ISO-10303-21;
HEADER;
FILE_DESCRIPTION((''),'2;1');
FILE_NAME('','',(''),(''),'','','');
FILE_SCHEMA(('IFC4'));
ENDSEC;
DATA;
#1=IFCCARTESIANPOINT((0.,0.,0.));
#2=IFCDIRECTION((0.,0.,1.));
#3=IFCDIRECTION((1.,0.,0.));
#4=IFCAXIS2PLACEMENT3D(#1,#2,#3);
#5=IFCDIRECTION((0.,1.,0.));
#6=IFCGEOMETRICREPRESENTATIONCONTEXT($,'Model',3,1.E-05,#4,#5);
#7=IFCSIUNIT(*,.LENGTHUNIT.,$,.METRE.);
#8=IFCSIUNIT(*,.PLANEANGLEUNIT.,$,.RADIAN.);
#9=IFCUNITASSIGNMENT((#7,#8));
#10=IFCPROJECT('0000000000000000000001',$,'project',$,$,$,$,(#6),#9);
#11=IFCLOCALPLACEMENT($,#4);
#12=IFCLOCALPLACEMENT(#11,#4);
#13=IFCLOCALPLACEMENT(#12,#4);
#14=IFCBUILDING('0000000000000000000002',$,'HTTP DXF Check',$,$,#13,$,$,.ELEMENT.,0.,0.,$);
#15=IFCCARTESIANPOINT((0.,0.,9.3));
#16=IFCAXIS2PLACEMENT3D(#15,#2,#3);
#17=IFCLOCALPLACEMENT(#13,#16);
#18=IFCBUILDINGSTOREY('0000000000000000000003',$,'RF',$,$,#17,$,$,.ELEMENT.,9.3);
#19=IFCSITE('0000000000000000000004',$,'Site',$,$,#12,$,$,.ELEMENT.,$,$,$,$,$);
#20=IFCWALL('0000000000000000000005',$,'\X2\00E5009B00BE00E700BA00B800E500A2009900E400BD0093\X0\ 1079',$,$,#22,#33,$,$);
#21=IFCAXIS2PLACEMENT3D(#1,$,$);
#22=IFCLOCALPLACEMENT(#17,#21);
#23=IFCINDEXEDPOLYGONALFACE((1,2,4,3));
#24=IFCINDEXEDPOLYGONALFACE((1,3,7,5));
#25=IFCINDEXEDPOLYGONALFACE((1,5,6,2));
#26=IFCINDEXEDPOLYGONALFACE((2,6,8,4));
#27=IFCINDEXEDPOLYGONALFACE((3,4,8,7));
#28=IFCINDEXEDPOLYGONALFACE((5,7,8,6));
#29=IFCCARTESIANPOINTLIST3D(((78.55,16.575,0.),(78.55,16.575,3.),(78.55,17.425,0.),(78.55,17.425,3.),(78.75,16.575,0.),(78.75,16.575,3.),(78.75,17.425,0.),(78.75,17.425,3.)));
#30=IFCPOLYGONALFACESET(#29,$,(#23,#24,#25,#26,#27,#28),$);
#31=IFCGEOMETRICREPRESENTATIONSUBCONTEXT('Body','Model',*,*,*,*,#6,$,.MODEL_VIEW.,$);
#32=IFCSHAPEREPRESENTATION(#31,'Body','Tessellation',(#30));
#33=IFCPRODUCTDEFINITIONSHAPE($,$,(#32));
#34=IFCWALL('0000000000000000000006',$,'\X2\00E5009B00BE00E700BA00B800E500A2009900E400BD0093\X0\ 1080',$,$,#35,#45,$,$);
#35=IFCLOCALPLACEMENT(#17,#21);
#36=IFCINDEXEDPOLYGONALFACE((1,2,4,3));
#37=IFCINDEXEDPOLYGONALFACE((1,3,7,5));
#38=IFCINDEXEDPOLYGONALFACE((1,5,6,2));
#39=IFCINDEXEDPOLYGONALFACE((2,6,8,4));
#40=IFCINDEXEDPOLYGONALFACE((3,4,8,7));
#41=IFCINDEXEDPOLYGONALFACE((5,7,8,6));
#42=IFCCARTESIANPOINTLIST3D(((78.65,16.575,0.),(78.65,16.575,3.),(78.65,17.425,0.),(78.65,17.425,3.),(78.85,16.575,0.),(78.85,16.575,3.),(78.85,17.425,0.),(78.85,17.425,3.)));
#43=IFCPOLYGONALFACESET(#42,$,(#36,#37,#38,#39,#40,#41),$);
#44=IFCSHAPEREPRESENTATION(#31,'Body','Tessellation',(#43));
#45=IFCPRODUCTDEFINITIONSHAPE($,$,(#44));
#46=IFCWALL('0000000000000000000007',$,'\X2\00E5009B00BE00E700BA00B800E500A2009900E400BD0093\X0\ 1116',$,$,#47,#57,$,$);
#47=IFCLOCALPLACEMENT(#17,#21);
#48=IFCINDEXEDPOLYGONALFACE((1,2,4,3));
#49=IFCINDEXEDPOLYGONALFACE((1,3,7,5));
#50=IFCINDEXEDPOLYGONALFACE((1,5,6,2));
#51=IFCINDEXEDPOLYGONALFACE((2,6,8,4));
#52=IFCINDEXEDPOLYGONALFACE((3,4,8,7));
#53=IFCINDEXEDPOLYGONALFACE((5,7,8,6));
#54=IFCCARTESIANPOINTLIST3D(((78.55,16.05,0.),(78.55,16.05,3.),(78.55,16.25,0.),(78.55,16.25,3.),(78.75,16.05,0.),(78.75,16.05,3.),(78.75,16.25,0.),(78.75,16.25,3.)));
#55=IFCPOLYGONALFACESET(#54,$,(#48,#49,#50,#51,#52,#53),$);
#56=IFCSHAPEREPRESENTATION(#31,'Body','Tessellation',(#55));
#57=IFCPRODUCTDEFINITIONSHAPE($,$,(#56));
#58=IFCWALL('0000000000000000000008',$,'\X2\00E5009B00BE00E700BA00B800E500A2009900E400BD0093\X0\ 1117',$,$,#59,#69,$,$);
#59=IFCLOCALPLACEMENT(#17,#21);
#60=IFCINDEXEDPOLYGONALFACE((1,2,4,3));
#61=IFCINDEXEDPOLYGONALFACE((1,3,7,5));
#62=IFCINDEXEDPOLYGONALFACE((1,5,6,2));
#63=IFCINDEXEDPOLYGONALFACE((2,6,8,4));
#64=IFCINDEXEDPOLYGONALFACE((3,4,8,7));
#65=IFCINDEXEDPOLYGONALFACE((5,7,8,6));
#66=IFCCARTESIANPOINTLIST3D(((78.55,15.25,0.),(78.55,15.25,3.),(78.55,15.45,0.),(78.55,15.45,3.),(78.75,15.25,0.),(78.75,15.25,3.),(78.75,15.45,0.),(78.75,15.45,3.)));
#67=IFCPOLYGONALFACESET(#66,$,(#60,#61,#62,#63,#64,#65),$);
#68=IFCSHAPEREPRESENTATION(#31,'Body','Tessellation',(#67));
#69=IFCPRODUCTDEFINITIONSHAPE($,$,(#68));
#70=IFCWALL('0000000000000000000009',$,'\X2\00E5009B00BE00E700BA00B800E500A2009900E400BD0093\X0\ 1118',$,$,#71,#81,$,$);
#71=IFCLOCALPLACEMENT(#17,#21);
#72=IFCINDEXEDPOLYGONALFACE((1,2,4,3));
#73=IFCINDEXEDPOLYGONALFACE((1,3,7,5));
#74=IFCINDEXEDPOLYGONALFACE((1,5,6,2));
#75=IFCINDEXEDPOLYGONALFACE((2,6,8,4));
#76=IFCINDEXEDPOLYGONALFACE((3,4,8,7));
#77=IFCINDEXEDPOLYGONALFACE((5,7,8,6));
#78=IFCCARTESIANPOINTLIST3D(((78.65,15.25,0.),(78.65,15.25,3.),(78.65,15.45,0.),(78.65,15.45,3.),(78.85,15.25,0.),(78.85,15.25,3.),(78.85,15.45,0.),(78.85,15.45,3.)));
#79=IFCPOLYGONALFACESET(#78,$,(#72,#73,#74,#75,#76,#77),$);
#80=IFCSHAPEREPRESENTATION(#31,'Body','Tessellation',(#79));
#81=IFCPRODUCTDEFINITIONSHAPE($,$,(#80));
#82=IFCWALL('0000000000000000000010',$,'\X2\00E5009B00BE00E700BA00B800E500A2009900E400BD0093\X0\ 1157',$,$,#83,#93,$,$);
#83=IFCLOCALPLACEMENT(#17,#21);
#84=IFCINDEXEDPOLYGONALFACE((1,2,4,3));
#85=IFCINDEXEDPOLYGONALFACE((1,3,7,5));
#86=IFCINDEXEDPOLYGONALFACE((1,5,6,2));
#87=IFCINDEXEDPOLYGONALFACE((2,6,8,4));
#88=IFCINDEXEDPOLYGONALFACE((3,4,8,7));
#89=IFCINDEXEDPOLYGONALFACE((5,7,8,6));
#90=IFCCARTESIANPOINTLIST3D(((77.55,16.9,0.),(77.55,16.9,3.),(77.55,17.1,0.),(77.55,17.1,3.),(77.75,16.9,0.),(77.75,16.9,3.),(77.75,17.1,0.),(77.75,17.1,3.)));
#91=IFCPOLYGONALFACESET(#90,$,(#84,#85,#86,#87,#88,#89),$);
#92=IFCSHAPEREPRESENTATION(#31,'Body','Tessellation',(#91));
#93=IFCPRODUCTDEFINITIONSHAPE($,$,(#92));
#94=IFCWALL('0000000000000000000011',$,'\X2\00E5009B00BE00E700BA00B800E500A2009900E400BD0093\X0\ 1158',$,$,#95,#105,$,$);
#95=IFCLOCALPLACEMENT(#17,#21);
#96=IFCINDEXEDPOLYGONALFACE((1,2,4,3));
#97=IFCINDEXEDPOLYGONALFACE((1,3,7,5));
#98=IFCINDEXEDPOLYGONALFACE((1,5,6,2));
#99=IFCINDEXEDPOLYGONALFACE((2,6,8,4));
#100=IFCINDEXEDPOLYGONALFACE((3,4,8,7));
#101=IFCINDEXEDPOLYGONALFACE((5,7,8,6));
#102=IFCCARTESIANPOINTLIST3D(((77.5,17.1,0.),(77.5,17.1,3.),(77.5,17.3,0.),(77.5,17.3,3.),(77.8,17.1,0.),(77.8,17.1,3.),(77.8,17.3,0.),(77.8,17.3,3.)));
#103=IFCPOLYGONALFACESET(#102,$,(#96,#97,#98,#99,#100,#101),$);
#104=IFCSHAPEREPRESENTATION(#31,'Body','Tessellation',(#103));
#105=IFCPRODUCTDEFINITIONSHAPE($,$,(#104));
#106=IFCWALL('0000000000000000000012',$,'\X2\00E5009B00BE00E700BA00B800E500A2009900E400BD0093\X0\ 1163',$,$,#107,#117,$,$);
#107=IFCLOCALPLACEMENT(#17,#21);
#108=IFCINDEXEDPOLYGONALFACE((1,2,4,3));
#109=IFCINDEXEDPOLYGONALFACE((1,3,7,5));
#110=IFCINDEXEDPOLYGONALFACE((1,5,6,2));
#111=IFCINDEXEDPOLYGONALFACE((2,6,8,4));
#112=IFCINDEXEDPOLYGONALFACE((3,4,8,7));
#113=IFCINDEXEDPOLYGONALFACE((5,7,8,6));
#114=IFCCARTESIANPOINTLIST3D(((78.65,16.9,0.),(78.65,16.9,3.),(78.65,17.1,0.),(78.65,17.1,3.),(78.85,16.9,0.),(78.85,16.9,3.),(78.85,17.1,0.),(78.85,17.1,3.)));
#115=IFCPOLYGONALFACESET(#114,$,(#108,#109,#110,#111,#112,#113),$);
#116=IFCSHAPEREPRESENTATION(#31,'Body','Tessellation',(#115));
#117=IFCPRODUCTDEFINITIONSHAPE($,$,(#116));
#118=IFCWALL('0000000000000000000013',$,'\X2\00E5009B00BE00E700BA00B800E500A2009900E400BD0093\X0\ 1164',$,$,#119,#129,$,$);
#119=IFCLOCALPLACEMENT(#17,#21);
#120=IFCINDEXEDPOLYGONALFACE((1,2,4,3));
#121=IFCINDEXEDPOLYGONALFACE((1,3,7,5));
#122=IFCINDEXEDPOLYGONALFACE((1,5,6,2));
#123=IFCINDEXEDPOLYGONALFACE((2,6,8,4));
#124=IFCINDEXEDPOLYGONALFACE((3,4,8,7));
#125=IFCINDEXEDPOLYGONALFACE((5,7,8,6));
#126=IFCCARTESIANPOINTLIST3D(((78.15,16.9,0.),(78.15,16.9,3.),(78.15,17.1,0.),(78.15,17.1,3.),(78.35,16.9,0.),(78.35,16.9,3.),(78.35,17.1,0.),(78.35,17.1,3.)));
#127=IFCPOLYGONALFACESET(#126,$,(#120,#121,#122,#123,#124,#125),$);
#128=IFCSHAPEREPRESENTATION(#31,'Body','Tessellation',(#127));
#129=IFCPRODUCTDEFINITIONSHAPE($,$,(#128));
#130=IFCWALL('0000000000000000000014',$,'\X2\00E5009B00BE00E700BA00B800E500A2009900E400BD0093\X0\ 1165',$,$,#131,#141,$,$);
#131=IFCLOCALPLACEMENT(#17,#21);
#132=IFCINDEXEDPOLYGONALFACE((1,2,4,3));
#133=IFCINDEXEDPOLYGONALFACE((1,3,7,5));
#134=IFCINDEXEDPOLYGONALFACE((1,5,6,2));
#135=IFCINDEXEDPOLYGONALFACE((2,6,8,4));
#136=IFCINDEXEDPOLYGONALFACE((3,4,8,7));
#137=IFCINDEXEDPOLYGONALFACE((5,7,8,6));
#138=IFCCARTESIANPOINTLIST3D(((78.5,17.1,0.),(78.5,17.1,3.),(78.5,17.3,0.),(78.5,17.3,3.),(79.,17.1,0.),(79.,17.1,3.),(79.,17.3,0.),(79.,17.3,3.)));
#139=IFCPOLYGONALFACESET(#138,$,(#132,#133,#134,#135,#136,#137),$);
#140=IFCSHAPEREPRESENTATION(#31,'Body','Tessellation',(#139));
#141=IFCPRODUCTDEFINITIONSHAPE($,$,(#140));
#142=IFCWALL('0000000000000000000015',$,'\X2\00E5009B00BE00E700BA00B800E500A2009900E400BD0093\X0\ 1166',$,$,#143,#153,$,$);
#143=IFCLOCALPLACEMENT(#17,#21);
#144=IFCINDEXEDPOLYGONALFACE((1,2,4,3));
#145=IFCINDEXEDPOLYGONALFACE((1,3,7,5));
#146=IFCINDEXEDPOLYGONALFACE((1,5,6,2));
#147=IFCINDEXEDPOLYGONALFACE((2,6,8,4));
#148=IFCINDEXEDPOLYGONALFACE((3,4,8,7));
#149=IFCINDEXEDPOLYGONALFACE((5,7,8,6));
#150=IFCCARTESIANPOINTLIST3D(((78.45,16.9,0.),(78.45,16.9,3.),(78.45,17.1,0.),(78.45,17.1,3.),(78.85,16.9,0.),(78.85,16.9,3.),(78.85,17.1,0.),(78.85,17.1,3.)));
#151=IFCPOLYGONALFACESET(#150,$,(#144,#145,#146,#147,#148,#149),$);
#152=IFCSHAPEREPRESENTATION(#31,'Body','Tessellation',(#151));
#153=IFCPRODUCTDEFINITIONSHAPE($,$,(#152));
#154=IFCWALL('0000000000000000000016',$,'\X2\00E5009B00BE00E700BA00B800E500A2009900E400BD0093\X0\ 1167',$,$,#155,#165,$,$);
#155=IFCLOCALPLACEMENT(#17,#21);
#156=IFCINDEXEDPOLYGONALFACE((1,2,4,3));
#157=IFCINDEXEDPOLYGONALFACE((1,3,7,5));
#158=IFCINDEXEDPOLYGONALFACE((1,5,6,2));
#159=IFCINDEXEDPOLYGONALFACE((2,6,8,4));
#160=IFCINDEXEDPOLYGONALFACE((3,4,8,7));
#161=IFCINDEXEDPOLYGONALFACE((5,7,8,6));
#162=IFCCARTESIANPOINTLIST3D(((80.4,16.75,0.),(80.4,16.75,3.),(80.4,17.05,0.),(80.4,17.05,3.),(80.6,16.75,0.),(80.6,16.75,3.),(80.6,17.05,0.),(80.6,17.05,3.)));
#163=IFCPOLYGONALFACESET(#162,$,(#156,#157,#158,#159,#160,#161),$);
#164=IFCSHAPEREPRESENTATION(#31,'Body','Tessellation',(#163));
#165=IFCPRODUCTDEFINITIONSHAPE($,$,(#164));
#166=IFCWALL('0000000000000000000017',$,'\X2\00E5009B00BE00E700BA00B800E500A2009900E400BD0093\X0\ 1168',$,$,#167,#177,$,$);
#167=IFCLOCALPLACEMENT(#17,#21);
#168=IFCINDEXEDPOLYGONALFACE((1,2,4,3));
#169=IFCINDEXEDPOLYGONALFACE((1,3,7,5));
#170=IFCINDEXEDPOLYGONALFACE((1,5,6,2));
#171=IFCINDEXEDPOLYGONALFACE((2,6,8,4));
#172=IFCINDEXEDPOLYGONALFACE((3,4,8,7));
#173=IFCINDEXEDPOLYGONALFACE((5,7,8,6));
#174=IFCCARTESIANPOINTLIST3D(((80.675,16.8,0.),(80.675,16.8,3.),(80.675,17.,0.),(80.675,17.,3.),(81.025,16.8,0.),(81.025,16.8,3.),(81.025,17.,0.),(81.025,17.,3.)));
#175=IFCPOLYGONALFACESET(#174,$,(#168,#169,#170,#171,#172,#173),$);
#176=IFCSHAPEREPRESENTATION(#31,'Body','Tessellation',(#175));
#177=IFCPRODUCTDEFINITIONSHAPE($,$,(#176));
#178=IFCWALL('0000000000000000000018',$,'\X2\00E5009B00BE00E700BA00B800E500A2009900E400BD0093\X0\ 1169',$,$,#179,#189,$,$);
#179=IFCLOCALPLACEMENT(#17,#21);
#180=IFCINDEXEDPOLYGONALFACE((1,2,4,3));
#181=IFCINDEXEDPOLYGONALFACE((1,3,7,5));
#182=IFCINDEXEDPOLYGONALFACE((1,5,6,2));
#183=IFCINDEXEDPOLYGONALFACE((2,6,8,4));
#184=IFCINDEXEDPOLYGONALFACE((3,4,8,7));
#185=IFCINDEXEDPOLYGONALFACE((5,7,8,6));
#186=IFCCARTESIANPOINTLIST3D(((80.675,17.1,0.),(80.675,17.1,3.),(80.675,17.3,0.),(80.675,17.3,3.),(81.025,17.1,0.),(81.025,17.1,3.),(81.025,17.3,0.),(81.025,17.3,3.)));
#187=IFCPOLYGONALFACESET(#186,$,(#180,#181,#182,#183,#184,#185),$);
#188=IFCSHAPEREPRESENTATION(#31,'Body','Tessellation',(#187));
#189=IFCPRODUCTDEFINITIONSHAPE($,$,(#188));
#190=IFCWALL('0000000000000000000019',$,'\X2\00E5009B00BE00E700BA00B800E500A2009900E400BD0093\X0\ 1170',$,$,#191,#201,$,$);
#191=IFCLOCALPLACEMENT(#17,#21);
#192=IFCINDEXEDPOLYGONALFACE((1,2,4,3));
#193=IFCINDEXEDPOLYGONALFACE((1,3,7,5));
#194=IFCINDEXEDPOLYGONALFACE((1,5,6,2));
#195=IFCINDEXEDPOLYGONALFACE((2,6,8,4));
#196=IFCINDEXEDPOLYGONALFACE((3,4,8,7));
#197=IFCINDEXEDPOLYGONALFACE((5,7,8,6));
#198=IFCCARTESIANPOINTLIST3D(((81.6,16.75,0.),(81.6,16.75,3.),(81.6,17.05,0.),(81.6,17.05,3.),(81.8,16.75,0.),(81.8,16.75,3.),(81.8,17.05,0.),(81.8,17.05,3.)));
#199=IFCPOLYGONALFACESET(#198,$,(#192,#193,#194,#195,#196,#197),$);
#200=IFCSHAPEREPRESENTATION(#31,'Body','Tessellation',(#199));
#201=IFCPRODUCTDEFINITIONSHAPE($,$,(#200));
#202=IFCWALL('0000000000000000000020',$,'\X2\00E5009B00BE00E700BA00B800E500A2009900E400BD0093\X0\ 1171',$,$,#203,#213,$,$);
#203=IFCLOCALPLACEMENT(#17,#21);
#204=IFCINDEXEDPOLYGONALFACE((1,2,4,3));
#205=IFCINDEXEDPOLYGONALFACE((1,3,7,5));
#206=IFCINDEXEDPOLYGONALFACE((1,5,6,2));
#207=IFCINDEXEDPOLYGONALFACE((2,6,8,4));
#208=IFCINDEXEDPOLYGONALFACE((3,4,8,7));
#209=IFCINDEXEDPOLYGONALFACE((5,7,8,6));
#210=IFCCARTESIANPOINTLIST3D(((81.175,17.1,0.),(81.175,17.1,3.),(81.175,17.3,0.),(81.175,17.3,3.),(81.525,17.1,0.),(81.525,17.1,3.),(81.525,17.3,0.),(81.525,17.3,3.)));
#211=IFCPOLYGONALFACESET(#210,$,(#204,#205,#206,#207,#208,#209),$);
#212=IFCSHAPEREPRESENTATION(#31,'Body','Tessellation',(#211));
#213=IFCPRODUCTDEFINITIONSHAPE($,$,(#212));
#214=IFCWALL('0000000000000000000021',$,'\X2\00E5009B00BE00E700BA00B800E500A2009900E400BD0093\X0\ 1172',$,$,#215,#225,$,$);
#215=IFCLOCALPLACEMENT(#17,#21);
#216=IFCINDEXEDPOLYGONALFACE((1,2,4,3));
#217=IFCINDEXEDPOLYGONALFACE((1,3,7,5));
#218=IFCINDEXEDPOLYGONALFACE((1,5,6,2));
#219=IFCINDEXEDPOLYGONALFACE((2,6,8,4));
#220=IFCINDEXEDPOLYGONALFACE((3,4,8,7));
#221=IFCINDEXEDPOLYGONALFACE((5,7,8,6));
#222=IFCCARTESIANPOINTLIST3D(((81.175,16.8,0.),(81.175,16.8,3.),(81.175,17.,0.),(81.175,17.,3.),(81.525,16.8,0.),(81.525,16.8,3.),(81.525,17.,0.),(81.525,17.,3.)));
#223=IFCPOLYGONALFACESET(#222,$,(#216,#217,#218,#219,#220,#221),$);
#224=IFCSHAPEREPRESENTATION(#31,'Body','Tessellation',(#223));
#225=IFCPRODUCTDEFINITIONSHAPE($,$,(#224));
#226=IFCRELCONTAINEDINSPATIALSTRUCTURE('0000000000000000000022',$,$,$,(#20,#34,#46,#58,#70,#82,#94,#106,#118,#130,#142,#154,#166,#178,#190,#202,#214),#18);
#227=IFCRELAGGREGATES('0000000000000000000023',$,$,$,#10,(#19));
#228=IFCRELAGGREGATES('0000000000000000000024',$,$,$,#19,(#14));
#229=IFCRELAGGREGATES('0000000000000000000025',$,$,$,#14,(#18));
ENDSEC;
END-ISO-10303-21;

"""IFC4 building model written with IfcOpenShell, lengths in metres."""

from ifc_helpers import new_model, si_unit, direction, frame, frame_2d, origin_with_axes, place, context, subcontext, project, spatial, rectangle, extrude, element, save


model = new_model("IFC4")

# Units and contexts
model_context = context("Model", 3, precision=1e-05, world=origin_with_axes(), true_north=direction((0.0, 1.0, 0.0)))
body_context = subcontext(model_context, "Body", "Model", "MODEL_VIEW")
ifc_project = project(units=[si_unit("LENGTHUNIT", "METRE"), si_unit("PLANEANGLEUNIT", "RADIAN")], contexts=[model_context])

# Site, building, storey
placement = place(None, origin_with_axes())
site_placement = place(placement, origin_with_axes())
site = spatial("IfcSite", under=ifc_project, at=site_placement, Name="Site", CompositionType="ELEMENT")
building_placement = place(site_placement, origin_with_axes())
building = spatial("IfcBuilding", under=site, at=building_placement, Name="HTTP DXF Check", CompositionType="ELEMENT", ElevationOfRefHeight=0.0, ElevationOfTerrain=0.0)
storey_placement = place(building_placement, frame((0.0, 0.0, 9.3), z_axis=(0.0, 0.0, 1.0), x_axis=(1.0, 0.0, 0.0)))
storey = spatial("IfcBuildingStorey", under=building, at=storey_placement, Name="RF", CompositionType="ELEMENT", Elevation=9.3)

# Walls
for number, where, z_axis, x_axis, name in (
    (1, (78.65, 17.0, 0.0), (0.0, 0.0, 1.0), (0.0, -1.0, 0.0), "å\u009b¾çº¸å¢\u0099ä½\u0093 1079"),
    (2, (78.75, 17.0, 0.0), (0.0, 0.0, 1.0), (0.0, -1.0, 0.0), "å\u009b¾çº¸å¢\u0099ä½\u0093 1080"),
):
    element("IfcWall", number, at=place(storey_placement, frame(where, z_axis=z_axis, x_axis=x_axis)), inside=storey, Name=name, context=body_context, shape_type="SweptSolid", body=[
        extrude(rectangle(XDim=0.85, YDim=0.2, at=frame_2d((0.0, 0.0), x_axis=(1.0, 0.0, 0.0))), frame((0.0, 0.0, 0.0), z_axis=(0.0, 0.0, 1.0)), (0.0, 0.0, 1.0), 3.0),
    ])
for number, where, z_axis, x_axis, name in (
    (3, (78.65, 16.15, 0.0), (0.0, 0.0, 1.0), (1.0, 0.0, 0.0), "å\u009b¾çº¸å¢\u0099ä½\u0093 1116"),
    (4, (78.65, 15.35, 0.0), (0.0, 0.0, 1.0), (1.0, 0.0, 0.0), "å\u009b¾çº¸å¢\u0099ä½\u0093 1117"),
    (5, (78.75, 15.35, 0.0), (0.0, 0.0, 1.0), (0.0, -1.0, 0.0), "å\u009b¾çº¸å¢\u0099ä½\u0093 1118"),
    (6, (77.65, 17.0, 0.0), (0.0, 0.0, 1.0), (-1.0, 0.0, 0.0), "å\u009b¾çº¸å¢\u0099ä½\u0093 1157"),
):
    element("IfcWall", number, at=place(storey_placement, frame(where, z_axis=z_axis, x_axis=x_axis)), inside=storey, Name=name, context=body_context, shape_type="SweptSolid", body=[
        extrude(rectangle(XDim=0.2, YDim=0.2, at=frame_2d((0.0, 0.0), x_axis=(1.0, 0.0, 0.0))), frame((0.0, 0.0, 0.0), z_axis=(0.0, 0.0, 1.0)), (0.0, 0.0, 1.0), 3.0),
    ])
wall_1_placement = place(storey_placement, frame((77.65, 17.2, 0.0), z_axis=(0.0, 0.0, 1.0), x_axis=(-1.0, 0.0, 0.0)))
element("IfcWall", 7, at=wall_1_placement, inside=storey, Name="å\u009b¾çº¸å¢\u0099ä½\u0093 1158", context=body_context, shape_type="SweptSolid", body=[
    extrude(rectangle(XDim=0.3, YDim=0.2, at=frame_2d((0.0, 0.0), x_axis=(1.0, 0.0, 0.0))), frame((0.0, 0.0, 0.0), z_axis=(0.0, 0.0, 1.0)), (0.0, 0.0, 1.0), 3.0),
])
for number, where, z_axis, x_axis, name in (
    (8, (78.75, 17.0, 0.0), (0.0, 0.0, 1.0), (0.0, 1.0, 0.0), "å\u009b¾çº¸å¢\u0099ä½\u0093 1163"),
    (9, (78.25, 17.0, 0.0), (0.0, 0.0, 1.0), (0.0, 1.0, 0.0), "å\u009b¾çº¸å¢\u0099ä½\u0093 1164"),
):
    element("IfcWall", number, at=place(storey_placement, frame(where, z_axis=z_axis, x_axis=x_axis)), inside=storey, Name=name, context=body_context, shape_type="SweptSolid", body=[
        extrude(rectangle(XDim=0.2, YDim=0.2, at=frame_2d((0.0, 0.0), x_axis=(1.0, 0.0, 0.0))), frame((0.0, 0.0, 0.0), z_axis=(0.0, 0.0, 1.0)), (0.0, 0.0, 1.0), 3.0),
    ])
wall_2_placement = place(storey_placement, frame((78.75, 17.2, 0.0), z_axis=(0.0, 0.0, 1.0), x_axis=(-1.0, 0.0, 0.0)))
element("IfcWall", 10, at=wall_2_placement, inside=storey, Name="å\u009b¾çº¸å¢\u0099ä½\u0093 1165", context=body_context, shape_type="SweptSolid", body=[
    extrude(rectangle(XDim=0.5, YDim=0.2, at=frame_2d((0.0, 0.0), x_axis=(1.0, 0.0, 0.0))), frame((0.0, 0.0, 0.0), z_axis=(0.0, 0.0, 1.0)), (0.0, 0.0, 1.0), 3.0),
])
wall_3_placement = place(storey_placement, frame((78.65, 17.0, 0.0), z_axis=(0.0, 0.0, 1.0), x_axis=(-1.0, 0.0, 0.0)))
element("IfcWall", 11, at=wall_3_placement, inside=storey, Name="å\u009b¾çº¸å¢\u0099ä½\u0093 1166", context=body_context, shape_type="SweptSolid", body=[
    extrude(rectangle(XDim=0.4, YDim=0.2, at=frame_2d((0.0, 0.0), x_axis=(1.0, 0.0, 0.0))), frame((0.0, 0.0, 0.0), z_axis=(0.0, 0.0, 1.0)), (0.0, 0.0, 1.0), 3.0),
])
wall_4_placement = place(storey_placement, frame((80.5, 16.9, 0.0), z_axis=(0.0, 0.0, 1.0), x_axis=(0.0, 1.0, 0.0)))
element("IfcWall", 12, at=wall_4_placement, inside=storey, Name="å\u009b¾çº¸å¢\u0099ä½\u0093 1167", context=body_context, shape_type="SweptSolid", body=[
    extrude(rectangle(XDim=0.3, YDim=0.2, at=frame_2d((0.0, 0.0), x_axis=(1.0, 0.0, 0.0))), frame((0.0, 0.0, 0.0), z_axis=(0.0, 0.0, 1.0)), (0.0, 0.0, 1.0), 3.0),
])
for number, where, z_axis, x_axis, name in (
    (13, (80.85, 16.9, 0.0), (0.0, 0.0, 1.0), (-1.0, 0.0, 0.0), "å\u009b¾çº¸å¢\u0099ä½\u0093 1168"),
    (14, (80.85, 17.2, 0.0), (0.0, 0.0, 1.0), (-1.0, 0.0, 0.0), "å\u009b¾çº¸å¢\u0099ä½\u0093 1169"),
):
    element("IfcWall", number, at=place(storey_placement, frame(where, z_axis=z_axis, x_axis=x_axis)), inside=storey, Name=name, context=body_context, shape_type="SweptSolid", body=[
        extrude(rectangle(XDim=0.35, YDim=0.2, at=frame_2d((0.0, 0.0), x_axis=(1.0, 0.0, 0.0))), frame((0.0, 0.0, 0.0), z_axis=(0.0, 0.0, 1.0)), (0.0, 0.0, 1.0), 3.0),
    ])
wall_5_placement = place(storey_placement, frame((81.7, 16.9, 0.0), z_axis=(0.0, 0.0, 1.0), x_axis=(0.0, 1.0, 0.0)))
element("IfcWall", 15, at=wall_5_placement, inside=storey, Name="å\u009b¾çº¸å¢\u0099ä½\u0093 1170", context=body_context, shape_type="SweptSolid", body=[
    extrude(rectangle(XDim=0.3, YDim=0.2, at=frame_2d((0.0, 0.0), x_axis=(1.0, 0.0, 0.0))), frame((0.0, 0.0, 0.0), z_axis=(0.0, 0.0, 1.0)), (0.0, 0.0, 1.0), 3.0),
])
for number, where, z_axis, x_axis, name in (
    (16, (81.35, 17.2, 0.0), (0.0, 0.0, 1.0), (1.0, 0.0, 0.0), "å\u009b¾çº¸å¢\u0099ä½\u0093 1171"),
    (17, (81.35, 16.9, 0.0), (0.0, 0.0, 1.0), (1.0, 0.0, 0.0), "å\u009b¾çº¸å¢\u0099ä½\u0093 1172"),
):
    element("IfcWall", number, at=place(storey_placement, frame(where, z_axis=z_axis, x_axis=x_axis)), inside=storey, Name=name, context=body_context, shape_type="SweptSolid", body=[
        extrude(rectangle(XDim=0.35, YDim=0.2, at=frame_2d((0.0, 0.0), x_axis=(1.0, 0.0, 0.0))), frame((0.0, 0.0, 0.0), z_axis=(0.0, 0.0, 1.0)), (0.0, 0.0, 1.0), 3.0),
    ])

save(model, "model.ifc")
